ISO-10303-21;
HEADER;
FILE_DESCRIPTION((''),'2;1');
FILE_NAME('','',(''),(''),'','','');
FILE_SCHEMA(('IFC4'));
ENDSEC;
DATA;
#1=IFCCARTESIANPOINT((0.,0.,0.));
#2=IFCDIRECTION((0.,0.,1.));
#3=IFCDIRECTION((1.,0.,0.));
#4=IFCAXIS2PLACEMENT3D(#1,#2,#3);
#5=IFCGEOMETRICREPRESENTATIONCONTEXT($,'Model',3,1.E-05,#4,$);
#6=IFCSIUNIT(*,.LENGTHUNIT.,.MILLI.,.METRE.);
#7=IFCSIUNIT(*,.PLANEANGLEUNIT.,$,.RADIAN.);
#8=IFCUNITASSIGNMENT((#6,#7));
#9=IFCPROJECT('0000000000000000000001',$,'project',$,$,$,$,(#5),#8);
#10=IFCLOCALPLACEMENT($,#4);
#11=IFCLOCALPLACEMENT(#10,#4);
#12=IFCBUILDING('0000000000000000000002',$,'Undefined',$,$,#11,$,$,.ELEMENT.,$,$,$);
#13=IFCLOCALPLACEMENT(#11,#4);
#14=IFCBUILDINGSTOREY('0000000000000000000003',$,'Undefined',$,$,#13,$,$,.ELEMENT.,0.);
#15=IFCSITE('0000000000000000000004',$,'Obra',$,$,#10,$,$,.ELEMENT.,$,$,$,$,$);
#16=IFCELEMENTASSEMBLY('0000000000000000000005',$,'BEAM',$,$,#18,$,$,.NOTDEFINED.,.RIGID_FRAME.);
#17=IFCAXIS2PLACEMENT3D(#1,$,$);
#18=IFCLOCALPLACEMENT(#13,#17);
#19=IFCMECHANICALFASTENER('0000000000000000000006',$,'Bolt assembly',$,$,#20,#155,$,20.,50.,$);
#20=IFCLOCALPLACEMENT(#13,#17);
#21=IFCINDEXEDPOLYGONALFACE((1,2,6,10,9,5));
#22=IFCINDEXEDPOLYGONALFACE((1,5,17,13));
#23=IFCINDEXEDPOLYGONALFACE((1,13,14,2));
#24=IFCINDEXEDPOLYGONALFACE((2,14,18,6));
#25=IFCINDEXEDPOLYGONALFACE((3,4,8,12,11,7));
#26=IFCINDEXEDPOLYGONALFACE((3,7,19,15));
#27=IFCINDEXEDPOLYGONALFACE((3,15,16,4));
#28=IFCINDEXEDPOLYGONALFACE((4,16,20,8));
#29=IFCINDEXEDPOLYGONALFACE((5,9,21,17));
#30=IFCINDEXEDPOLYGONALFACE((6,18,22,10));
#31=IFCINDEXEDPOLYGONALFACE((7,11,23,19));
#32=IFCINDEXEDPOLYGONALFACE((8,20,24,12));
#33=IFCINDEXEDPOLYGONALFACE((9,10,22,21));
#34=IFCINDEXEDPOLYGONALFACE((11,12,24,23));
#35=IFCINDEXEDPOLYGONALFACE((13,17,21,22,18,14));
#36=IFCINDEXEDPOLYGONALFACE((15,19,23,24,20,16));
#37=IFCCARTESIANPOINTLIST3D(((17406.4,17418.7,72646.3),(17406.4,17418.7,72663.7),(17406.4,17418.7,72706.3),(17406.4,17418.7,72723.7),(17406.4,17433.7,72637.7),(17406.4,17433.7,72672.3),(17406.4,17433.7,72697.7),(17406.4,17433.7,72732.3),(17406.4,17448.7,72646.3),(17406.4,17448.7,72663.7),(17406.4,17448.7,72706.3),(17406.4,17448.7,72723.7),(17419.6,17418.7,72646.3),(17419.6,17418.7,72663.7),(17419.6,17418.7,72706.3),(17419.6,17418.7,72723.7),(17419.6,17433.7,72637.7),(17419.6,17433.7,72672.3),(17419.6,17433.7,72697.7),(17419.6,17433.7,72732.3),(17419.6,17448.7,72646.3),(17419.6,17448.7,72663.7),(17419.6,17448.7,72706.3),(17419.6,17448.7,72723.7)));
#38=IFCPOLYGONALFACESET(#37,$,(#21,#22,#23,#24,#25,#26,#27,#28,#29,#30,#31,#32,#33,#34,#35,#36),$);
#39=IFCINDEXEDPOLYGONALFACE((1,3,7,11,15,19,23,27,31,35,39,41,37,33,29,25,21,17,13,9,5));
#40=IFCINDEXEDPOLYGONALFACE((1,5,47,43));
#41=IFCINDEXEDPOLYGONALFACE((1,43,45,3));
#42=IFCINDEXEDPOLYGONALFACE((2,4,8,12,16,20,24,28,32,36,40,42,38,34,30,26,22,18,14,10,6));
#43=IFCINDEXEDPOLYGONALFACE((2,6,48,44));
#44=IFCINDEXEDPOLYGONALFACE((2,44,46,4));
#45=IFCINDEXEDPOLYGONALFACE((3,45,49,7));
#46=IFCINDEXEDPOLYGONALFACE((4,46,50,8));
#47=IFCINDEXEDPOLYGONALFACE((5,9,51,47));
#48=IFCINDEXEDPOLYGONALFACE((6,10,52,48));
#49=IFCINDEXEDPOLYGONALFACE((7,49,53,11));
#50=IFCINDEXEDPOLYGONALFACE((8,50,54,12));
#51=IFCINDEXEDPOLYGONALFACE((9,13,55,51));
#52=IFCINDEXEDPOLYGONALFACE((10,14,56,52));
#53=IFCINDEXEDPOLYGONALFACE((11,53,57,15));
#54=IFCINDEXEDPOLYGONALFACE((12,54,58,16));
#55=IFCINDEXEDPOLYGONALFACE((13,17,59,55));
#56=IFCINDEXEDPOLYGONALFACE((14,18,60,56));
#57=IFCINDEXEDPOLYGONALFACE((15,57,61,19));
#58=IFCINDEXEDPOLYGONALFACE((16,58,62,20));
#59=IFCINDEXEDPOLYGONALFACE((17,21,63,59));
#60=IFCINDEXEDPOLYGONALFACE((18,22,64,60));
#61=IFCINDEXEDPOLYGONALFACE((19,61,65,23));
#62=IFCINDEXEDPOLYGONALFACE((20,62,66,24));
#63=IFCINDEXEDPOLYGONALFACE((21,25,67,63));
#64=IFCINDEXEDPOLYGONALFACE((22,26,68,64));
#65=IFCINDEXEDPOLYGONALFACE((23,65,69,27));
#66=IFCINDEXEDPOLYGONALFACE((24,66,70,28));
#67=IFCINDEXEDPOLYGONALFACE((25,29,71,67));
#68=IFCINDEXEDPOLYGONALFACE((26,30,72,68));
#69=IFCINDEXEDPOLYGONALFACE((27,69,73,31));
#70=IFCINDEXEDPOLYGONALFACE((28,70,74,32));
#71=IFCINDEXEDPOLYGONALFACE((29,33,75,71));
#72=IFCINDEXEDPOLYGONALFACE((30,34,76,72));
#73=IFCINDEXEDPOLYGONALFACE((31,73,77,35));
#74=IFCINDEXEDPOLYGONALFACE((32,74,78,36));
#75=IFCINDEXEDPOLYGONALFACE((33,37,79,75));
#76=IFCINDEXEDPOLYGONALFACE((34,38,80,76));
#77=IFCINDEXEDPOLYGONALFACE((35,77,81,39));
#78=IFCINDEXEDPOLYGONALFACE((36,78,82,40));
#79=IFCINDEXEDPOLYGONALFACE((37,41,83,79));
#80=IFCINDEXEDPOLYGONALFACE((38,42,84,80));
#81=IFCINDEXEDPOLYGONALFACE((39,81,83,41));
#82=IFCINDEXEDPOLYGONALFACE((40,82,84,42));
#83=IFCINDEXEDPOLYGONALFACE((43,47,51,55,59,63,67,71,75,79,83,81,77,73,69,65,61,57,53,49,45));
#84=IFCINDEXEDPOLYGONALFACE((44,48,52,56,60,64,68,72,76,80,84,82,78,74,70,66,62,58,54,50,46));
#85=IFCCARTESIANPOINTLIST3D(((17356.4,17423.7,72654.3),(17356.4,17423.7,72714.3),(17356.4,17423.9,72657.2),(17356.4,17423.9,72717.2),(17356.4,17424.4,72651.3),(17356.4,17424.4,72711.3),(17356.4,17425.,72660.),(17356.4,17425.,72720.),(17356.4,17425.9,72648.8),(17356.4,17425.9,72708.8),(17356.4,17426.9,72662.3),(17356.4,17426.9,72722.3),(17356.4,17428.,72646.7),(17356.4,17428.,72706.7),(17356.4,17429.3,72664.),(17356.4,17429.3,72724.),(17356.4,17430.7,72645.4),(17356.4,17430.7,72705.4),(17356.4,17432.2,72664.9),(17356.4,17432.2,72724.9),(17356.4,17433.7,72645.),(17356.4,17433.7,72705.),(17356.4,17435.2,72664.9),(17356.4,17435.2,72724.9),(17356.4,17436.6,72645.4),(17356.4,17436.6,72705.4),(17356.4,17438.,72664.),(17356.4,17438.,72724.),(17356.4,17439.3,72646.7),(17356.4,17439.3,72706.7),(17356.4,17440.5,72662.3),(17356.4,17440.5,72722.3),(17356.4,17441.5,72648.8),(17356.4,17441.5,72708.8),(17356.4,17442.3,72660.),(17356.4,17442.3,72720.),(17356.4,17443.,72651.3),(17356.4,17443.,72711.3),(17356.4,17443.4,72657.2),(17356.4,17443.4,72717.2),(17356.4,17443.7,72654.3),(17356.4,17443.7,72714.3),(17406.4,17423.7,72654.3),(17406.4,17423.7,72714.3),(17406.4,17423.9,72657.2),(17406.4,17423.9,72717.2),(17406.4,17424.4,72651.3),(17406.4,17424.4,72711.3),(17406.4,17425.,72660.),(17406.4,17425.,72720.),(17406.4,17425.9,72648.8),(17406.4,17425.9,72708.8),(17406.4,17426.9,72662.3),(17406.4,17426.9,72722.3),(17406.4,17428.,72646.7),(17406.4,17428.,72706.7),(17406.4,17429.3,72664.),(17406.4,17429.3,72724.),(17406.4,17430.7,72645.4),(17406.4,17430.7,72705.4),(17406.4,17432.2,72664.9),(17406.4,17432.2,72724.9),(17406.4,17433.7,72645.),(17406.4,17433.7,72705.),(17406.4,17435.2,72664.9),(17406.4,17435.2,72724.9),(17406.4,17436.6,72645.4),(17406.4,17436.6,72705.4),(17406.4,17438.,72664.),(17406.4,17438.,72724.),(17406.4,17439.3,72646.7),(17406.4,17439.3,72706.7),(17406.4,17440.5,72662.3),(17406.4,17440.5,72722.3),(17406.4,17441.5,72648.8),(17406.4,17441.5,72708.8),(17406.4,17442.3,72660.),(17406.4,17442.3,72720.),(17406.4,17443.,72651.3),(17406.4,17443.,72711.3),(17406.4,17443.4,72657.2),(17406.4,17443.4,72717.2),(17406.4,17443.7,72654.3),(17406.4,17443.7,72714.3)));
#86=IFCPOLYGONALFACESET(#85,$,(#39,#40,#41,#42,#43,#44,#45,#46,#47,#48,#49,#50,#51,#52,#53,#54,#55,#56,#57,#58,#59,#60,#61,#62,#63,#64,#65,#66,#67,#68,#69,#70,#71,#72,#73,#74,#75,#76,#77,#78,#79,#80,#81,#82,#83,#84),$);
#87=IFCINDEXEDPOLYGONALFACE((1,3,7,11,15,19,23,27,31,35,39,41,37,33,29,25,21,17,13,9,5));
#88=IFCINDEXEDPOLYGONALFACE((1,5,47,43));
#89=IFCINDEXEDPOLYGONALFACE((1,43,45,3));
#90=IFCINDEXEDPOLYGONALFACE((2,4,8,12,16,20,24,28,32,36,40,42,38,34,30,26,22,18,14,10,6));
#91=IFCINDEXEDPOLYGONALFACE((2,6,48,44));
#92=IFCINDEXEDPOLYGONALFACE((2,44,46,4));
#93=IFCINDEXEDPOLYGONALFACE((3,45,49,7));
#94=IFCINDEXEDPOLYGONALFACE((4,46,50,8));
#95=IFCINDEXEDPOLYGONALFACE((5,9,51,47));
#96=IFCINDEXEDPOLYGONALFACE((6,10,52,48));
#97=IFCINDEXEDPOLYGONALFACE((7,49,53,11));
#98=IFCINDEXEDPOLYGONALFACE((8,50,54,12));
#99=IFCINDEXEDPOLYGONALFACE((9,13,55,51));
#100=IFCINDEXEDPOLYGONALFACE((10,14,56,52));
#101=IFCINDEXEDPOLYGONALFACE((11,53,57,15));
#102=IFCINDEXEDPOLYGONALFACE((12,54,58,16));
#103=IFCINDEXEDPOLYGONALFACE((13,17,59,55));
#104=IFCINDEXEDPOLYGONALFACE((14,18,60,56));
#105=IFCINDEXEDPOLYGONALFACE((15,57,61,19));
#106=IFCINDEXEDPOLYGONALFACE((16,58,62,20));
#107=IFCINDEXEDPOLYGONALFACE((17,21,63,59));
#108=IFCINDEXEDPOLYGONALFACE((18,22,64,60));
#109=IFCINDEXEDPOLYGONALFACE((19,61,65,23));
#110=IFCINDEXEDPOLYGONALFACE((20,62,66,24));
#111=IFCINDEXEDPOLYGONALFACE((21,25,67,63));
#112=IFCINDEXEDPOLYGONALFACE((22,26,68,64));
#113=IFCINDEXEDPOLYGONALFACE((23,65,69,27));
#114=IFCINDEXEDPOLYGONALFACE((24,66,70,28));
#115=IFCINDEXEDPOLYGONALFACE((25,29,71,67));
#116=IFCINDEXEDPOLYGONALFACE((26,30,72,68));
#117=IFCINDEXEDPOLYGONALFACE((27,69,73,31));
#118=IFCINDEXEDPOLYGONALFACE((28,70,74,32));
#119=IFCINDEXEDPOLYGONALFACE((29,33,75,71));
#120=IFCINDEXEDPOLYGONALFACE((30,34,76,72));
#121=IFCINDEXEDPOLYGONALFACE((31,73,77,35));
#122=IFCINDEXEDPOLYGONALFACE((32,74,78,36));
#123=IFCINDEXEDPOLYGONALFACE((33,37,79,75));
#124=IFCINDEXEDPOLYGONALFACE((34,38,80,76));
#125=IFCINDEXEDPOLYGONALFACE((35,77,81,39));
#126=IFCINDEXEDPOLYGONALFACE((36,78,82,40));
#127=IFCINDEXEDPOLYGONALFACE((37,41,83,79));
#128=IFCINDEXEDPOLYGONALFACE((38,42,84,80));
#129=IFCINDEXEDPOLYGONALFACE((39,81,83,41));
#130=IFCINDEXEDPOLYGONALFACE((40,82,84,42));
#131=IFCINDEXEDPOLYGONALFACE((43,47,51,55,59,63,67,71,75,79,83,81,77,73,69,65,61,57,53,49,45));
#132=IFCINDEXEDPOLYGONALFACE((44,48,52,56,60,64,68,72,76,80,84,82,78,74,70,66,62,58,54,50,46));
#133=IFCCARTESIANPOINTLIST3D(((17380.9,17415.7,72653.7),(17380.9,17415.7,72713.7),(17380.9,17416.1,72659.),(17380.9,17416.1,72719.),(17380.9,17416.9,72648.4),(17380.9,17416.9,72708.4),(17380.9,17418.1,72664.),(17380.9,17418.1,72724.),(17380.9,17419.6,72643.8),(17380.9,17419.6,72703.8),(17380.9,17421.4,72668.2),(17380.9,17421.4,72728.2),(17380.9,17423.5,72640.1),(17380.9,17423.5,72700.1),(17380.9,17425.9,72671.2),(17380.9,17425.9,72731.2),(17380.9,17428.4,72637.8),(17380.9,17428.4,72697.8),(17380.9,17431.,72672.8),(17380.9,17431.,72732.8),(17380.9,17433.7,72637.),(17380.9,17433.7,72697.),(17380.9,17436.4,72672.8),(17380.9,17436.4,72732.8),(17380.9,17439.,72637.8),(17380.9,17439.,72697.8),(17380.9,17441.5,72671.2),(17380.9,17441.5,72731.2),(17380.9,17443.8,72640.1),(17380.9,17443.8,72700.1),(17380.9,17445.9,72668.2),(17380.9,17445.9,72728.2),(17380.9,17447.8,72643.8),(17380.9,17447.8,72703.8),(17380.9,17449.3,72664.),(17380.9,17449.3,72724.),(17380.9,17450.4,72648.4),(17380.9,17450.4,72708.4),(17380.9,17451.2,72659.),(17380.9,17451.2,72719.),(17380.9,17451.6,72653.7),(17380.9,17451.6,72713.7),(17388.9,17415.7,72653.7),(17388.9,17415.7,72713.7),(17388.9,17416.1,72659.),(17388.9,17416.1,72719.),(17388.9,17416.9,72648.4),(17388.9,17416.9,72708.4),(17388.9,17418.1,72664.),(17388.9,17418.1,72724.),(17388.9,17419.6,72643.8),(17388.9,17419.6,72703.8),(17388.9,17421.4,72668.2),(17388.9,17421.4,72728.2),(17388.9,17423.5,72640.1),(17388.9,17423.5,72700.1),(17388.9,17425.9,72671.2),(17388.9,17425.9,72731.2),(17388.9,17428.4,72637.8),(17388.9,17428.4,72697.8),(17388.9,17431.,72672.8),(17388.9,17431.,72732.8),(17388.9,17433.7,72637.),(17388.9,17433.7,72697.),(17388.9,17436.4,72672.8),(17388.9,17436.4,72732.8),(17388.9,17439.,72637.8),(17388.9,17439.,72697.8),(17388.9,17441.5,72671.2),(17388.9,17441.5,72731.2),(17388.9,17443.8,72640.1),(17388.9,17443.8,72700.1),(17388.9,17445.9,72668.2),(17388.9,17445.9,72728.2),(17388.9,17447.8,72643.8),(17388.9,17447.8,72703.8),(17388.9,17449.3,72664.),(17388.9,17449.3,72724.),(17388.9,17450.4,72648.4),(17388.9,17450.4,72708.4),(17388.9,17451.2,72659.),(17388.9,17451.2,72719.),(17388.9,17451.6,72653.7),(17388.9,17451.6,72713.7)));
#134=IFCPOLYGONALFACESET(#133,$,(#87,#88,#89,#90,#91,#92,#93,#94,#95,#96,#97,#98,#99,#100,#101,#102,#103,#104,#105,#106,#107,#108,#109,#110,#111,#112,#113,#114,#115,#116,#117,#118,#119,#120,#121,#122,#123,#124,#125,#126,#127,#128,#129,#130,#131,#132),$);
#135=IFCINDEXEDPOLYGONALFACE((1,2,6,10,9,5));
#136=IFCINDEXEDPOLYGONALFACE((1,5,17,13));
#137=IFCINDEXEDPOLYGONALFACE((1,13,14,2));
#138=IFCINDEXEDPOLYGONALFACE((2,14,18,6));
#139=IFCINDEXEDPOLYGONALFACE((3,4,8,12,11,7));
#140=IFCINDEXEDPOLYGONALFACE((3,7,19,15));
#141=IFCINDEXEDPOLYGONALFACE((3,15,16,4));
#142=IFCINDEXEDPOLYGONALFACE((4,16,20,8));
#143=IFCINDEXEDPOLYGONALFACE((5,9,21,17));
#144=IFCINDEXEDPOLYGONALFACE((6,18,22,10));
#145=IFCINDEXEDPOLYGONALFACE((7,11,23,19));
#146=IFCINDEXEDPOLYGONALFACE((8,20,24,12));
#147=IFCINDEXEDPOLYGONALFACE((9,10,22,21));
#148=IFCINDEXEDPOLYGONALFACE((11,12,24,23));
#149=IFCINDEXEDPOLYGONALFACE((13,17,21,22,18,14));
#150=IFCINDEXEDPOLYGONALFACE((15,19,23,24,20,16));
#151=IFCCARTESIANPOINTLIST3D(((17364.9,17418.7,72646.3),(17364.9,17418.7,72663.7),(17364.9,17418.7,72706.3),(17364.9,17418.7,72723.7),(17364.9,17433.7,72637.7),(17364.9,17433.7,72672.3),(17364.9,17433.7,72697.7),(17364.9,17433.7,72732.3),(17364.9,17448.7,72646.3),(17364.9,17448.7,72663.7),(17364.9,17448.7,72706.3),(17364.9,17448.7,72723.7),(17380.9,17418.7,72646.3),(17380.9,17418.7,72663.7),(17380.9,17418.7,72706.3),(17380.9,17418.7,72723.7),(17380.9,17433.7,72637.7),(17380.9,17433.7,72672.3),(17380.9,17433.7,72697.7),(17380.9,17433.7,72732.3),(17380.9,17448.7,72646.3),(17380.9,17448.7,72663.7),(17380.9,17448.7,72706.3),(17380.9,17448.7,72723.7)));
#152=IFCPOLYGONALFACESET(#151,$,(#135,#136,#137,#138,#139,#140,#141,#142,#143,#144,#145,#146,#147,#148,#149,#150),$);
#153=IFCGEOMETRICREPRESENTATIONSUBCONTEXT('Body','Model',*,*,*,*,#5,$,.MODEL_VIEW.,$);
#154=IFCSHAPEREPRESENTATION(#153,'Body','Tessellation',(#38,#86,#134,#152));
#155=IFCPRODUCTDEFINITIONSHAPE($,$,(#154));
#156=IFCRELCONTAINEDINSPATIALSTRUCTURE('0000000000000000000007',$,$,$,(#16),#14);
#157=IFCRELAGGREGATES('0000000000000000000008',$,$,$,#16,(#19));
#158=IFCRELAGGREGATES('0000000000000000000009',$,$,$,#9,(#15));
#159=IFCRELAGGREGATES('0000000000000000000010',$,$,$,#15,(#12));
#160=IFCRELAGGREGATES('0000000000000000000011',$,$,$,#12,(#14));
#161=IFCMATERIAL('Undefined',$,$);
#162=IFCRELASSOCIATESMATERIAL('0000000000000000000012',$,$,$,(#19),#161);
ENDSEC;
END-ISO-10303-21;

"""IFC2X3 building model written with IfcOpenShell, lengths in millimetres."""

from ifc_helpers import new_model, si_unit, frame, origin_with_axes, origin_2d_with_axis, place, context, subcontext, project, spatial, polyline, circle, outline, extrude, source, transform, mapped, material, element, aggregate, save


model = new_model("IFC2X3")

# Units and contexts
model_context = context("Model", 3, precision=1e-05, world=origin_with_axes())
body_context = subcontext(model_context, "Body", "Model", "MODEL_VIEW")
ifc_project = project(units=[si_unit("LENGTHUNIT", "METRE", prefix="MILLI"), si_unit("PLANEANGLEUNIT", "RADIAN")], contexts=[model_context])

# Site, building, storey
site_placement = place(None, origin_with_axes())
site = spatial("IfcSite", under=ifc_project, at=site_placement, Name="Obra", CompositionType="ELEMENT")
building_placement = place(site_placement, origin_with_axes())
building = spatial("IfcBuilding", under=site, at=building_placement, Name="Undefined", CompositionType="ELEMENT")
storey_placement = place(building_placement, origin_with_axes())
storey = spatial("IfcBuildingStorey", under=building, at=storey_placement, Name="Undefined", CompositionType="ELEMENT", Elevation=0.0)

# Shared definitions
ifc_material = material(Name="Undefined")

# Element assembly, mechanical fastener
assembly_1_placement = place(storey_placement, origin_with_axes())
assembly_1 = element("IfcElementAssembly", 1, at=assembly_1_placement, inside=storey, Name="BEAM", AssemblyPlace="NOTDEFINED", PredefinedType="RIGID_FRAME")
shared_shape_1 = source(origin_with_axes(), body_context, "Body", "SweptSolid", [
    extrude(outline(polyline([(17.3, 0.0), (8.7, 15.0), (-8.7, 15.0), (-17.3, 0.0), (-8.7, -15.0), (8.7, -15.0), (17.3, 0.0)])), frame((0.0, -27.0, 0.0), z_axis=(0.0, 1.0, 0.0), x_axis=(1.0, 0.0, 0.0)), (0.0, 0.0, 1.0), 13.2),
    extrude(circle(Radius=10.0, at=origin_2d_with_axis()), frame((0.0, -13.8, 0.0), z_axis=(0.0, 1.0, 0.0), x_axis=(1.0, 0.0, 0.0)), (0.0, 0.0, 1.0), 50.0),
    extrude(circle(Radius=18.0, at=origin_2d_with_axis()), frame((0.0, 3.7, 0.0), z_axis=(0.0, 1.0, 0.0), x_axis=(1.0, 0.0, 0.0)), (0.0, 0.0, 1.0), 8.0),
    extrude(outline(polyline([(17.3, 0.0), (8.7, 15.0), (-8.7, 15.0), (-17.3, 0.0), (-8.7, -15.0), (8.7, -15.0), (17.3, 0.0)])), frame((0.0, 11.7, 0.0), z_axis=(0.0, 1.0, 0.0), x_axis=(1.0, 0.0, 0.0)), (0.0, 0.0, 1.0), 16.0),
])
mechanical_fastener_1_placement = place(assembly_1_placement, frame((17392.7, 17393.7, 72850.0), z_axis=(0.0, 1.0, 0.0), x_axis=(0.0, 0.0, -1.0)))
mechanical_fastener_1 = element("IfcMechanicalFastener", 2, at=mechanical_fastener_1_placement, material=ifc_material, Name="Bolt assembly", NominalDiameter=20.0, NominalLength=50.0, context=body_context, shape_type="MappedRepresentation", body=[
    mapped(shared_shape_1, transform((135.0, 0.0, 40.0))),
    mapped(shared_shape_1, transform((195.0, 0.0, 40.0))),
])

aggregate(assembly_1, [mechanical_fastener_1])

save(model, "model.ifc")
